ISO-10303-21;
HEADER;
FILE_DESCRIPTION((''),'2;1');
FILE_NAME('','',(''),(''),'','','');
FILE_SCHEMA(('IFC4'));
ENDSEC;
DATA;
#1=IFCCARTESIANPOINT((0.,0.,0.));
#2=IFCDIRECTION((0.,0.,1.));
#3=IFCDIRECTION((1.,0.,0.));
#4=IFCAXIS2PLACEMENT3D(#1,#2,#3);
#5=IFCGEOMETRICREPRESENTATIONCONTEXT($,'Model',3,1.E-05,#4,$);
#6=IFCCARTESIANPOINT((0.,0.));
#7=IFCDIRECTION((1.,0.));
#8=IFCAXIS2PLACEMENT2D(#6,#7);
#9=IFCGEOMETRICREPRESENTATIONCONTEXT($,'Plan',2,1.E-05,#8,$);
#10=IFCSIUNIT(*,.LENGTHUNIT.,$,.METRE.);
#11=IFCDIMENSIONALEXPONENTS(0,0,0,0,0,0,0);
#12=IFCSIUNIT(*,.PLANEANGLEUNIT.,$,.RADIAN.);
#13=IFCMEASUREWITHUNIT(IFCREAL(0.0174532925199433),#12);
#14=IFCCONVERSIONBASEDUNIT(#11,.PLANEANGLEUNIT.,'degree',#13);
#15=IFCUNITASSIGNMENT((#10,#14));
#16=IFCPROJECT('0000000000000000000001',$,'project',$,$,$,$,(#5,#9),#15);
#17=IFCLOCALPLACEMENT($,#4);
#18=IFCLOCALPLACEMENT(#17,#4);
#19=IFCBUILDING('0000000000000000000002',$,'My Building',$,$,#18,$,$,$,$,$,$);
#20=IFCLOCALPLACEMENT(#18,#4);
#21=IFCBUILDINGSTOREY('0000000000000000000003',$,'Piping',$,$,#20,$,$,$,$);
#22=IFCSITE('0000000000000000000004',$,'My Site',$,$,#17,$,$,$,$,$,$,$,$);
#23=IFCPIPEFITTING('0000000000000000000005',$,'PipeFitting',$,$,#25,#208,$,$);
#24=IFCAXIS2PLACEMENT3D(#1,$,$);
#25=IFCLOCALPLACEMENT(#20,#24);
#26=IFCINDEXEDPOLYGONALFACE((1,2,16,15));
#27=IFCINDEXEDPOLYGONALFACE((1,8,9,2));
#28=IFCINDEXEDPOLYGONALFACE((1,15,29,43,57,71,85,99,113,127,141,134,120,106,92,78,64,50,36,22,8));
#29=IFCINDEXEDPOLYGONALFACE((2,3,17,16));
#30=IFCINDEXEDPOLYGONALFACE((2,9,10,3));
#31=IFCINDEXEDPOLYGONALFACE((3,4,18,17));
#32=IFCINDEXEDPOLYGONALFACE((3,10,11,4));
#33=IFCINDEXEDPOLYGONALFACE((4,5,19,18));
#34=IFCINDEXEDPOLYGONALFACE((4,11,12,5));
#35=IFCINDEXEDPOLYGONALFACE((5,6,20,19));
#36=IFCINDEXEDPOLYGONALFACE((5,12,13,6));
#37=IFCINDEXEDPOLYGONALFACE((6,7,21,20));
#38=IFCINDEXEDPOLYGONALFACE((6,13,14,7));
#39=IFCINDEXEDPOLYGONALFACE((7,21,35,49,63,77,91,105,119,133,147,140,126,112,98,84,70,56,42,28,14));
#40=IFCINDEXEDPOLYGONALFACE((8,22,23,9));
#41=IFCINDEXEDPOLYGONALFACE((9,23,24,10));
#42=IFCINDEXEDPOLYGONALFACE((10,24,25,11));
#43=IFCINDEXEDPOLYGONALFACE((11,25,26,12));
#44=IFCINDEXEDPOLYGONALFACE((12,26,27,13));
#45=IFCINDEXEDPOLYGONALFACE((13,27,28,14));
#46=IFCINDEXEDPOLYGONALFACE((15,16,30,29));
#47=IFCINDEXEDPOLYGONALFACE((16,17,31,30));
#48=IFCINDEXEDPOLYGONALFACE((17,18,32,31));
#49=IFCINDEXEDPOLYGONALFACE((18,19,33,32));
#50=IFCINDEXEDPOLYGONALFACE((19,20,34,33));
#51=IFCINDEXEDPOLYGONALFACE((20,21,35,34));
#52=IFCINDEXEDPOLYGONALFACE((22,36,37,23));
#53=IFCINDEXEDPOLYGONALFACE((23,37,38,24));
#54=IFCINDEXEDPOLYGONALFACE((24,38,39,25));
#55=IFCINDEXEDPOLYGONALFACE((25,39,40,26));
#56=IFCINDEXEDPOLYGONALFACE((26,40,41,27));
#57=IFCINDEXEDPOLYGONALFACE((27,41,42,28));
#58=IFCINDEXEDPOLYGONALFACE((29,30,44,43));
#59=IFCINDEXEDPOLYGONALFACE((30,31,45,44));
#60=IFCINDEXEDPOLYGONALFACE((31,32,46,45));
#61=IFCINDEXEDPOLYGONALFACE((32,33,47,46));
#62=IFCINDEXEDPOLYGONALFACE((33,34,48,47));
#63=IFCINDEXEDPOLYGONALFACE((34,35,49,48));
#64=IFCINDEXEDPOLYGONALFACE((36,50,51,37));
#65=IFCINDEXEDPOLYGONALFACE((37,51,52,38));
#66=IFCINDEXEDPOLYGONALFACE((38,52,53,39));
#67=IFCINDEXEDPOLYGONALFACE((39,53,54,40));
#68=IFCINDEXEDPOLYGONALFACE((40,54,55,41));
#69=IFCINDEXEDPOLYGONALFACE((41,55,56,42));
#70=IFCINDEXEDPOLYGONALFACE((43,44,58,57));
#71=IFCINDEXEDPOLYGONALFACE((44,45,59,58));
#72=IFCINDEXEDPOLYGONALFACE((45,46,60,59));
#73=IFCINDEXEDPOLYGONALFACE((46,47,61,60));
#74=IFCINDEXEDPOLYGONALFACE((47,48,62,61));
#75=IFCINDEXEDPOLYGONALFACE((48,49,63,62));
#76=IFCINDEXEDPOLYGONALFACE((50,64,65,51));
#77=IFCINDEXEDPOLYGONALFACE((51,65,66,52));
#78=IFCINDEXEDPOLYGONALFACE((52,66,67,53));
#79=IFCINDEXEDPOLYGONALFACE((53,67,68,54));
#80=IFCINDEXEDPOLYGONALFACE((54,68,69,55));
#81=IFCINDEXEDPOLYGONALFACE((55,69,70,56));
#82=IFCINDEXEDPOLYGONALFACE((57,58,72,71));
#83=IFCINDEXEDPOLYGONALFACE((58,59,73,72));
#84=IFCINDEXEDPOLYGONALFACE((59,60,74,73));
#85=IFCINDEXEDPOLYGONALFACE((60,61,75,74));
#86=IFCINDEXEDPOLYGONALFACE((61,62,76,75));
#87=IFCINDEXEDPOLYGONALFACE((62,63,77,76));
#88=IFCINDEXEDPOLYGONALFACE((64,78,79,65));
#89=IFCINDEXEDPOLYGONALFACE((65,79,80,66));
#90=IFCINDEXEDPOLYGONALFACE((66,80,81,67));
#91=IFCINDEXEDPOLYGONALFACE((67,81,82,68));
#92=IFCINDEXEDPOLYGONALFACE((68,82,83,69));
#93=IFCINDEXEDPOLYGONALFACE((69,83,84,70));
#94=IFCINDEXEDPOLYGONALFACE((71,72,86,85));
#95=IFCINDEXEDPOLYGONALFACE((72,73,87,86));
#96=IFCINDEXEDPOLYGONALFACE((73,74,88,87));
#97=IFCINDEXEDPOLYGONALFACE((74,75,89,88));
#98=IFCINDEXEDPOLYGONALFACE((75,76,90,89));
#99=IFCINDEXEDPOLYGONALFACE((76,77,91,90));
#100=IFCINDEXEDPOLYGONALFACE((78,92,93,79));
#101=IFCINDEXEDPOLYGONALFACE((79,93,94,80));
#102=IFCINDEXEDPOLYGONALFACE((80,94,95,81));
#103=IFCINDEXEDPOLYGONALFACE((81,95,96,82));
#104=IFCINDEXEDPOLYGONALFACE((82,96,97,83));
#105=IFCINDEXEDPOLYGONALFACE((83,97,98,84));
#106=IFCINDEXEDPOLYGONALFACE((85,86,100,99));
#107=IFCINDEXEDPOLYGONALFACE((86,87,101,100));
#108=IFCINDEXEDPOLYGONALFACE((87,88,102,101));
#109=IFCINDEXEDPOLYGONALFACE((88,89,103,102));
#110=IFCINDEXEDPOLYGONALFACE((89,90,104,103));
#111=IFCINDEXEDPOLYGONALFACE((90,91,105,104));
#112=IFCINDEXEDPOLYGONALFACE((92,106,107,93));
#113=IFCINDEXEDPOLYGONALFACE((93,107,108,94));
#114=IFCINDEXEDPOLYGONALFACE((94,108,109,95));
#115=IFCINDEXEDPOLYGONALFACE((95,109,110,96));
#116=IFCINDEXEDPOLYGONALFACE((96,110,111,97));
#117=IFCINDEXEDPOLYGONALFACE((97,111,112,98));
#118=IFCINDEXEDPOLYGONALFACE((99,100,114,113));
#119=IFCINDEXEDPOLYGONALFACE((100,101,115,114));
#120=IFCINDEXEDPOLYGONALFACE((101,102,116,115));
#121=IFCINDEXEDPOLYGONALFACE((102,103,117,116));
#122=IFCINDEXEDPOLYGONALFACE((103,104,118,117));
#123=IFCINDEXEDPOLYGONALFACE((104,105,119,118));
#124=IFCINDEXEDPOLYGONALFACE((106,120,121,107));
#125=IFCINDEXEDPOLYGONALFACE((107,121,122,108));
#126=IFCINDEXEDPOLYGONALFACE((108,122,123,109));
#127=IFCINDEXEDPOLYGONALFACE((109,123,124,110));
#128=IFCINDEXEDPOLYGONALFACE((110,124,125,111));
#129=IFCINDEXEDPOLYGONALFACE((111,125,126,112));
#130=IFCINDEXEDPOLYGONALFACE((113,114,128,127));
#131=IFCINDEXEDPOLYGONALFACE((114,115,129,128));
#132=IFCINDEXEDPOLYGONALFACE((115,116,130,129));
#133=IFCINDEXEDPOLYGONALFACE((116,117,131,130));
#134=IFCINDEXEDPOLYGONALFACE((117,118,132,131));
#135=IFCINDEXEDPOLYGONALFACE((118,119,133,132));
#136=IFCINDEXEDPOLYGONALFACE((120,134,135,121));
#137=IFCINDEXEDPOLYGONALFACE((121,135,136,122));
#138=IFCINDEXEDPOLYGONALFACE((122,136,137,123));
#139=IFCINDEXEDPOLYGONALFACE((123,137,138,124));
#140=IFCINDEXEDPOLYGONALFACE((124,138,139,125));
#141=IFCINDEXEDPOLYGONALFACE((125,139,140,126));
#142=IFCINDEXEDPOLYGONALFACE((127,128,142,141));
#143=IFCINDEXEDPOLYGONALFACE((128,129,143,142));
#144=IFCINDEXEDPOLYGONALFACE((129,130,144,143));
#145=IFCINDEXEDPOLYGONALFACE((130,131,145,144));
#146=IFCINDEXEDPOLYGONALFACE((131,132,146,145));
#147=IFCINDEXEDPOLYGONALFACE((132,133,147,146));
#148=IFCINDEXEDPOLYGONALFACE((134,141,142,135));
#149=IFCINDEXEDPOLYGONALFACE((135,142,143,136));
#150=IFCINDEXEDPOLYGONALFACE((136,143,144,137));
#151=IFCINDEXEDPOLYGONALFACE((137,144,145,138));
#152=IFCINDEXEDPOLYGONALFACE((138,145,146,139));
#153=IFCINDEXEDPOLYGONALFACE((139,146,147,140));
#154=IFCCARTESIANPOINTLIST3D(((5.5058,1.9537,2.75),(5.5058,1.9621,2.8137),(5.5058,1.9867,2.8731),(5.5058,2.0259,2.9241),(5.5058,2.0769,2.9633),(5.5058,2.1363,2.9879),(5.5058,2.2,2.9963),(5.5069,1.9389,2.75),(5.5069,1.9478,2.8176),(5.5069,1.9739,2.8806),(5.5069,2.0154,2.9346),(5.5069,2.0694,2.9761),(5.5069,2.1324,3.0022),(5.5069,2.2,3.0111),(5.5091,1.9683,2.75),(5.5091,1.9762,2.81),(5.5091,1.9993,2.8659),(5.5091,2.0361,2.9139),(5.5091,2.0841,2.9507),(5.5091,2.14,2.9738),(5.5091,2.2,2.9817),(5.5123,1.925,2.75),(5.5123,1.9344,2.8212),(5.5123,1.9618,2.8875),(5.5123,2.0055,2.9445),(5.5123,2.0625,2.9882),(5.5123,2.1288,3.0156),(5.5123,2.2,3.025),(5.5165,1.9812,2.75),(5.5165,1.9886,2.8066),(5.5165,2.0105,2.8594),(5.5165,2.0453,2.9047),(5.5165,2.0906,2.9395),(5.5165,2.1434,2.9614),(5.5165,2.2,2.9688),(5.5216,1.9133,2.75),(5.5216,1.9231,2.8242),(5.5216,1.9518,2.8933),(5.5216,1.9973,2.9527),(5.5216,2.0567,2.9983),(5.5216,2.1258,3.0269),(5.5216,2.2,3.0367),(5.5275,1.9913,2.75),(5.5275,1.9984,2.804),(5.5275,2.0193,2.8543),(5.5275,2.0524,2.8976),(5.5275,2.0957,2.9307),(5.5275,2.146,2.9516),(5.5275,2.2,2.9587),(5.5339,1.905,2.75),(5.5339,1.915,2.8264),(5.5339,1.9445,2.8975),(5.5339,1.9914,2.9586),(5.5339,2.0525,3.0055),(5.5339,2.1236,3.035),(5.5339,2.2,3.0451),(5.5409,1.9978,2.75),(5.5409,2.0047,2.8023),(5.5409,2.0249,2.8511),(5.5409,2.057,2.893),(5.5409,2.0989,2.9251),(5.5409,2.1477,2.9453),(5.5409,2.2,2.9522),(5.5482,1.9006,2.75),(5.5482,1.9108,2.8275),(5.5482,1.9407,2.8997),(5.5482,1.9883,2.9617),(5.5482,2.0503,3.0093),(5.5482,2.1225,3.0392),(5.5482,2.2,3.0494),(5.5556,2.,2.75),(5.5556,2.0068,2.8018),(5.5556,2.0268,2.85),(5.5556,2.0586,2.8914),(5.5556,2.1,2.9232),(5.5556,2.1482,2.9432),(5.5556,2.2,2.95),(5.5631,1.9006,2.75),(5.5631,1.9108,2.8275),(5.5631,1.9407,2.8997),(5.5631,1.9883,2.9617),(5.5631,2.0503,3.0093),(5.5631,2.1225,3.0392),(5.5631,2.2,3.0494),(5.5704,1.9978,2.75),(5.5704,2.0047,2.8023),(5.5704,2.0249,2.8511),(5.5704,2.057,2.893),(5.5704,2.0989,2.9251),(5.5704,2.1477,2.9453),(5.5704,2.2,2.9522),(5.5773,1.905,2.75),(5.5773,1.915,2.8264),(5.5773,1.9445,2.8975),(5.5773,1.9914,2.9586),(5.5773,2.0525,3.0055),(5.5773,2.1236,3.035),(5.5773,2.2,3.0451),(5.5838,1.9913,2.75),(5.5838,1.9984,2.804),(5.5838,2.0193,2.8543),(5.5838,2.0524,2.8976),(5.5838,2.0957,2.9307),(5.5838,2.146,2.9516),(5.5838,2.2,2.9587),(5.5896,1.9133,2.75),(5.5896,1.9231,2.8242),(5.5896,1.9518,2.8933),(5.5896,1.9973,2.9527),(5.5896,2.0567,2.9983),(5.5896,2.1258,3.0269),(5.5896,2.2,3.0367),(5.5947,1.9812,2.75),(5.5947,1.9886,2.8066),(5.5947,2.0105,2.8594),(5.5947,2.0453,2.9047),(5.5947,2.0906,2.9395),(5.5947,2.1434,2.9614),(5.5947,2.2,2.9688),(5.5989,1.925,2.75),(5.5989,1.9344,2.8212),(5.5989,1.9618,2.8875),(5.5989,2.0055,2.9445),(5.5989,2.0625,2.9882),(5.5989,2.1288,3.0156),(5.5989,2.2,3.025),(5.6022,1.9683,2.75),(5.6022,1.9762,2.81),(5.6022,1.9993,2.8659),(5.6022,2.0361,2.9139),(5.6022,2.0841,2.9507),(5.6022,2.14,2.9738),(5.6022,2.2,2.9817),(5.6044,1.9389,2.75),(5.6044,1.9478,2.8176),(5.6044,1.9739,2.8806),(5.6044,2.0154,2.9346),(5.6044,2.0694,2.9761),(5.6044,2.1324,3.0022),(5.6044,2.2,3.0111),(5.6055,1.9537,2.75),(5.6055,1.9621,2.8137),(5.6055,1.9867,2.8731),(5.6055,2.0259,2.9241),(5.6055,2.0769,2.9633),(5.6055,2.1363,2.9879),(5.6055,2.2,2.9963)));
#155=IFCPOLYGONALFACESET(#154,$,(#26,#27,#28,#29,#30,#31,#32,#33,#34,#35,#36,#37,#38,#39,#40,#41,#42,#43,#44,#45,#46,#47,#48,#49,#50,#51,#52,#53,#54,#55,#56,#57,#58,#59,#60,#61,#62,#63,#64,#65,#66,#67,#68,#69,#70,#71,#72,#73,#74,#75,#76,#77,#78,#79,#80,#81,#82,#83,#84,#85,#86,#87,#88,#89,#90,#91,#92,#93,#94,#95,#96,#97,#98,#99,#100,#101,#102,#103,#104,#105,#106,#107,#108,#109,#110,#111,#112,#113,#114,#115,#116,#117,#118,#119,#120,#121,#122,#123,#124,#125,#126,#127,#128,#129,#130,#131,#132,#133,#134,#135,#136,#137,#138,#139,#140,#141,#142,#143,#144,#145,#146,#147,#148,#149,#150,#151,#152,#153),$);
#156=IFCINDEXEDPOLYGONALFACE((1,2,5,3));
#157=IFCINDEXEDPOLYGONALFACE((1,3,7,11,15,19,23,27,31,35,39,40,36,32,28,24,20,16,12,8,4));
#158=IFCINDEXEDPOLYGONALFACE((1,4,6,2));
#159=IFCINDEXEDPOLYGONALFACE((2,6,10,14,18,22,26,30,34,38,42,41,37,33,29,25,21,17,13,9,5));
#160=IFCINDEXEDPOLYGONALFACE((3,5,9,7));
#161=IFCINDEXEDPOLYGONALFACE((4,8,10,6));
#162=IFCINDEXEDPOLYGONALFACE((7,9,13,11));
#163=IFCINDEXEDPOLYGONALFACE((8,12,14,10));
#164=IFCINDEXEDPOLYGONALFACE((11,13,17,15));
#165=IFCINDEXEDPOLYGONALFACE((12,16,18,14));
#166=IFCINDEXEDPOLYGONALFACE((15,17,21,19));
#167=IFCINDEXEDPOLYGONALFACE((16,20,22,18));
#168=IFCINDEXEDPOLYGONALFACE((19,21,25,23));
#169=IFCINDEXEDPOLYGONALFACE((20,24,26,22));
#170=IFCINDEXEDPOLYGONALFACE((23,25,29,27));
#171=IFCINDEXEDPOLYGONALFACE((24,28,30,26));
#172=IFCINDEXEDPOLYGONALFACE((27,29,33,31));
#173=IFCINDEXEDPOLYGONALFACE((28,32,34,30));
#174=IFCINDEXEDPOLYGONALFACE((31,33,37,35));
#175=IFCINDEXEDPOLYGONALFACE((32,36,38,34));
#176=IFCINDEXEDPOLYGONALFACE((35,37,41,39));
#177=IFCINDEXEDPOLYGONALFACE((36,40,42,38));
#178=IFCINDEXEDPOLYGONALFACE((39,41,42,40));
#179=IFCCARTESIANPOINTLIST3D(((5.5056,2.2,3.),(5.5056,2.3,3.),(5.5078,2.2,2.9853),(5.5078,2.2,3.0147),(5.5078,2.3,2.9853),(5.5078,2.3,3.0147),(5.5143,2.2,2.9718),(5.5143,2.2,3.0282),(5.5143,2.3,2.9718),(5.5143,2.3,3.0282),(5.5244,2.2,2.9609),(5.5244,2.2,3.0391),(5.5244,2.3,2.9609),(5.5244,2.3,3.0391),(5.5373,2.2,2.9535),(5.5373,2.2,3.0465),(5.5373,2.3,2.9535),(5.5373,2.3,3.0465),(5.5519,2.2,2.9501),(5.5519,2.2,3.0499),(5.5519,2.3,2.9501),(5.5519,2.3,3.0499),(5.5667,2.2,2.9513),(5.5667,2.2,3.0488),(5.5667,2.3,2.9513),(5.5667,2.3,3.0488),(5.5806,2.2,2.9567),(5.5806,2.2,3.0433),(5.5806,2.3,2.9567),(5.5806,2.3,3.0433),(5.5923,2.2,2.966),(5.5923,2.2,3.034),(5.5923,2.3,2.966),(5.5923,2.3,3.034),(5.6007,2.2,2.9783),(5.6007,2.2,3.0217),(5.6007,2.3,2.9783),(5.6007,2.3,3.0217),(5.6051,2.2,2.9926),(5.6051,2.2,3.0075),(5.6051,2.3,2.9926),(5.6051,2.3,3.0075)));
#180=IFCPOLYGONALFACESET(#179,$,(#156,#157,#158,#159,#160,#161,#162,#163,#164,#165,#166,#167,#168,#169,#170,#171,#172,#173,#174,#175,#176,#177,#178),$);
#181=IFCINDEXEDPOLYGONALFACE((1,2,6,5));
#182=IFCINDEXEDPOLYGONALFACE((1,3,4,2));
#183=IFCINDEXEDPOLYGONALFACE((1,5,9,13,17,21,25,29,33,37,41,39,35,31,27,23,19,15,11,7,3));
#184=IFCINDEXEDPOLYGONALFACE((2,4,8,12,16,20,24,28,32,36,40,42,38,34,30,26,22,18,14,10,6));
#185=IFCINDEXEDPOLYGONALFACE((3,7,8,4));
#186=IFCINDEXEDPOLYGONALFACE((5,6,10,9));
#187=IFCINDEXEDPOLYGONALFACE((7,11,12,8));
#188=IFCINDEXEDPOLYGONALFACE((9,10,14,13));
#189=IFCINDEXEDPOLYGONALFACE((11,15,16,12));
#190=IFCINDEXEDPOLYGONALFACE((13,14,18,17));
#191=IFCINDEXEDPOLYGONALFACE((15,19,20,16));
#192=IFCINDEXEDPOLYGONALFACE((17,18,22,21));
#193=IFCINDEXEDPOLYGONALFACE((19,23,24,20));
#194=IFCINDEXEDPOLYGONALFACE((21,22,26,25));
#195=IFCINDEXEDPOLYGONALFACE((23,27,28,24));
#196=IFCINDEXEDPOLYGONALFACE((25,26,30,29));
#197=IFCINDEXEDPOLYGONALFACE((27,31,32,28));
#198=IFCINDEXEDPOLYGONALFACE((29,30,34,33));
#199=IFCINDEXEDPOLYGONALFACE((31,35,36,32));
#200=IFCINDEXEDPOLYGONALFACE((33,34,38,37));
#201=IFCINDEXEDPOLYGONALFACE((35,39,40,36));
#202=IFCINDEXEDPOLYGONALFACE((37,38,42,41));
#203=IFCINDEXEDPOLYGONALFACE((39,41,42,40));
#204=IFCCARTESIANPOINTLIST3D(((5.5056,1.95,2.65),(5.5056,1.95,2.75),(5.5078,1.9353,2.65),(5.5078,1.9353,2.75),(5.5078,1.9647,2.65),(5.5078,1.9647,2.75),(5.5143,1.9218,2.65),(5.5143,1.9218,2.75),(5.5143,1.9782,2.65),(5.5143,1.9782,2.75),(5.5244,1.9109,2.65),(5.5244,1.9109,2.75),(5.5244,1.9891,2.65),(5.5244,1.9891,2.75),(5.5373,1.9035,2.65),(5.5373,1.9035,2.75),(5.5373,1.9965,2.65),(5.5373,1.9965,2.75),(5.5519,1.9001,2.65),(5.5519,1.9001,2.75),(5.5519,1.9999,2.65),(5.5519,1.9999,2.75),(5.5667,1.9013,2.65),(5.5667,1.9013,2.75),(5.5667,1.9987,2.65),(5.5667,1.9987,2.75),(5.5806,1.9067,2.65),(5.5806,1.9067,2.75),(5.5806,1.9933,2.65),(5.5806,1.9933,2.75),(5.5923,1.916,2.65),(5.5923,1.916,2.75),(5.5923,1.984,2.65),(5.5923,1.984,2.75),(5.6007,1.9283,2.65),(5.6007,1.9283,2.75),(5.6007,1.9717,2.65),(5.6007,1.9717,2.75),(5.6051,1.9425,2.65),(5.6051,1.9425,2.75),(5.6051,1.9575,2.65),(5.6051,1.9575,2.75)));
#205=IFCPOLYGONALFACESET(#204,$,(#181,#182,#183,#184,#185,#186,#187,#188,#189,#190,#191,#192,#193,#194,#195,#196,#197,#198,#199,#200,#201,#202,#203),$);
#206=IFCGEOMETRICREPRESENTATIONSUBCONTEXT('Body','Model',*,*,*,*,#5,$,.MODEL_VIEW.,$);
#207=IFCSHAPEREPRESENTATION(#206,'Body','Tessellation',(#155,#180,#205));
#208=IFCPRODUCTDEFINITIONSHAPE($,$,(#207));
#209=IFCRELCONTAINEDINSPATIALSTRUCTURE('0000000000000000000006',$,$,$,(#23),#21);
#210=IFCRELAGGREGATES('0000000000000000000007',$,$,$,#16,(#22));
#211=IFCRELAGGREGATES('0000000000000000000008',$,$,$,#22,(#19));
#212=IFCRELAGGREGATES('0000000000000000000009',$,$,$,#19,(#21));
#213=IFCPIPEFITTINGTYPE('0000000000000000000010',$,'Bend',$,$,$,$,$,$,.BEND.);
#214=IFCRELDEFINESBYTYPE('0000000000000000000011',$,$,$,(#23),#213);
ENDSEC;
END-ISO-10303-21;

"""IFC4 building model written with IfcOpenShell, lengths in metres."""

from ifc_helpers import new_model, entity, si_unit, converted_unit, frame, origin_with_axes, origin_2d_with_axis, place, context, subcontext, project, spatial, circle, extrude, source, transform, mapped, type_object, type_shapes, element, save


model = new_model("IFC4")

# Units and contexts
model_context = context("Model", 3, precision=1e-05, world=origin_with_axes())
plan_context = context("Plan", 2, precision=1e-05, world=origin_2d_with_axis())
body_context = subcontext(model_context, "Body", "Model", "MODEL_VIEW")
ifc_project = project(units=[si_unit("LENGTHUNIT", "METRE"), converted_unit("PLANEANGLEUNIT", "degree", entity("IfcReal", 0.0174532925199433), si_unit("PLANEANGLEUNIT", "RADIAN"), dimensions=[0, 0, 0, 0, 0, 0, 0])], contexts=[model_context, plan_context])

# Site, building, storey
site_placement = place(None, origin_with_axes())
site = spatial("IfcSite", under=ifc_project, at=site_placement, Name="My Site")
building_placement = place(site_placement, origin_with_axes())
building = spatial("IfcBuilding", under=site, at=building_placement, Name="My Building")
storey_placement = place(building_placement, origin_with_axes())
storey = spatial("IfcBuildingStorey", under=building, at=storey_placement, Name="Piping")

# Pipe fitting
pipe_fitting_type = type_object("IfcPipeFittingType", Name="Bend", PredefinedType="BEND")
shared_shape = source(origin_with_axes(), body_context, "Body", "SolidModel", [
    entity("IfcSweptDiskSolid", entity("IfcIndexedPolyCurve", entity("IfcCartesianPointList3D", [[0.0, 0.0, -0.1], [0.0, -0.0732, -0.2768], [0.0, -0.25, -0.35]]), [entity("IfcArcIndex", [1, 2, 3])]), 0.05),
    extrude(circle(Radius=0.05), origin_with_axes(), (0.0, 0.0, -1.0), 0.1),
    extrude(circle(Radius=0.05), frame((0.0, -0.25, -0.35), z_axis=(0.0, -1.0, 0.0), x_axis=(1.0, 0.0, 0.0)), (0.0, 0.0, 1.0), 0.1),
])
type_shapes(pipe_fitting_type, [shared_shape])
for number, where, z_axis, x_axis, name in (
    (1, (5.5556, 2.3, 3.0), (0.0, 1.0, 0.0), (-1.0, 0.0, 0.0), "PipeFitting"),
):
    element("IfcPipeFitting", number, at=place(storey_placement, frame(where, z_axis=z_axis, x_axis=x_axis)), inside=storey, type_object=pipe_fitting_type, Name=name, context=body_context, shape_type="MappedRepresentation", body=[
        mapped(shared_shape, transform((0.0, 0.0, 0.0), x_axis=(1.0, 0.0, 0.0), y_axis=(0.0, 1.0, 0.0), z_axis=(0.0, 0.0, 1.0), scale=1.0)),
    ])

save(model, "model.ifc")
